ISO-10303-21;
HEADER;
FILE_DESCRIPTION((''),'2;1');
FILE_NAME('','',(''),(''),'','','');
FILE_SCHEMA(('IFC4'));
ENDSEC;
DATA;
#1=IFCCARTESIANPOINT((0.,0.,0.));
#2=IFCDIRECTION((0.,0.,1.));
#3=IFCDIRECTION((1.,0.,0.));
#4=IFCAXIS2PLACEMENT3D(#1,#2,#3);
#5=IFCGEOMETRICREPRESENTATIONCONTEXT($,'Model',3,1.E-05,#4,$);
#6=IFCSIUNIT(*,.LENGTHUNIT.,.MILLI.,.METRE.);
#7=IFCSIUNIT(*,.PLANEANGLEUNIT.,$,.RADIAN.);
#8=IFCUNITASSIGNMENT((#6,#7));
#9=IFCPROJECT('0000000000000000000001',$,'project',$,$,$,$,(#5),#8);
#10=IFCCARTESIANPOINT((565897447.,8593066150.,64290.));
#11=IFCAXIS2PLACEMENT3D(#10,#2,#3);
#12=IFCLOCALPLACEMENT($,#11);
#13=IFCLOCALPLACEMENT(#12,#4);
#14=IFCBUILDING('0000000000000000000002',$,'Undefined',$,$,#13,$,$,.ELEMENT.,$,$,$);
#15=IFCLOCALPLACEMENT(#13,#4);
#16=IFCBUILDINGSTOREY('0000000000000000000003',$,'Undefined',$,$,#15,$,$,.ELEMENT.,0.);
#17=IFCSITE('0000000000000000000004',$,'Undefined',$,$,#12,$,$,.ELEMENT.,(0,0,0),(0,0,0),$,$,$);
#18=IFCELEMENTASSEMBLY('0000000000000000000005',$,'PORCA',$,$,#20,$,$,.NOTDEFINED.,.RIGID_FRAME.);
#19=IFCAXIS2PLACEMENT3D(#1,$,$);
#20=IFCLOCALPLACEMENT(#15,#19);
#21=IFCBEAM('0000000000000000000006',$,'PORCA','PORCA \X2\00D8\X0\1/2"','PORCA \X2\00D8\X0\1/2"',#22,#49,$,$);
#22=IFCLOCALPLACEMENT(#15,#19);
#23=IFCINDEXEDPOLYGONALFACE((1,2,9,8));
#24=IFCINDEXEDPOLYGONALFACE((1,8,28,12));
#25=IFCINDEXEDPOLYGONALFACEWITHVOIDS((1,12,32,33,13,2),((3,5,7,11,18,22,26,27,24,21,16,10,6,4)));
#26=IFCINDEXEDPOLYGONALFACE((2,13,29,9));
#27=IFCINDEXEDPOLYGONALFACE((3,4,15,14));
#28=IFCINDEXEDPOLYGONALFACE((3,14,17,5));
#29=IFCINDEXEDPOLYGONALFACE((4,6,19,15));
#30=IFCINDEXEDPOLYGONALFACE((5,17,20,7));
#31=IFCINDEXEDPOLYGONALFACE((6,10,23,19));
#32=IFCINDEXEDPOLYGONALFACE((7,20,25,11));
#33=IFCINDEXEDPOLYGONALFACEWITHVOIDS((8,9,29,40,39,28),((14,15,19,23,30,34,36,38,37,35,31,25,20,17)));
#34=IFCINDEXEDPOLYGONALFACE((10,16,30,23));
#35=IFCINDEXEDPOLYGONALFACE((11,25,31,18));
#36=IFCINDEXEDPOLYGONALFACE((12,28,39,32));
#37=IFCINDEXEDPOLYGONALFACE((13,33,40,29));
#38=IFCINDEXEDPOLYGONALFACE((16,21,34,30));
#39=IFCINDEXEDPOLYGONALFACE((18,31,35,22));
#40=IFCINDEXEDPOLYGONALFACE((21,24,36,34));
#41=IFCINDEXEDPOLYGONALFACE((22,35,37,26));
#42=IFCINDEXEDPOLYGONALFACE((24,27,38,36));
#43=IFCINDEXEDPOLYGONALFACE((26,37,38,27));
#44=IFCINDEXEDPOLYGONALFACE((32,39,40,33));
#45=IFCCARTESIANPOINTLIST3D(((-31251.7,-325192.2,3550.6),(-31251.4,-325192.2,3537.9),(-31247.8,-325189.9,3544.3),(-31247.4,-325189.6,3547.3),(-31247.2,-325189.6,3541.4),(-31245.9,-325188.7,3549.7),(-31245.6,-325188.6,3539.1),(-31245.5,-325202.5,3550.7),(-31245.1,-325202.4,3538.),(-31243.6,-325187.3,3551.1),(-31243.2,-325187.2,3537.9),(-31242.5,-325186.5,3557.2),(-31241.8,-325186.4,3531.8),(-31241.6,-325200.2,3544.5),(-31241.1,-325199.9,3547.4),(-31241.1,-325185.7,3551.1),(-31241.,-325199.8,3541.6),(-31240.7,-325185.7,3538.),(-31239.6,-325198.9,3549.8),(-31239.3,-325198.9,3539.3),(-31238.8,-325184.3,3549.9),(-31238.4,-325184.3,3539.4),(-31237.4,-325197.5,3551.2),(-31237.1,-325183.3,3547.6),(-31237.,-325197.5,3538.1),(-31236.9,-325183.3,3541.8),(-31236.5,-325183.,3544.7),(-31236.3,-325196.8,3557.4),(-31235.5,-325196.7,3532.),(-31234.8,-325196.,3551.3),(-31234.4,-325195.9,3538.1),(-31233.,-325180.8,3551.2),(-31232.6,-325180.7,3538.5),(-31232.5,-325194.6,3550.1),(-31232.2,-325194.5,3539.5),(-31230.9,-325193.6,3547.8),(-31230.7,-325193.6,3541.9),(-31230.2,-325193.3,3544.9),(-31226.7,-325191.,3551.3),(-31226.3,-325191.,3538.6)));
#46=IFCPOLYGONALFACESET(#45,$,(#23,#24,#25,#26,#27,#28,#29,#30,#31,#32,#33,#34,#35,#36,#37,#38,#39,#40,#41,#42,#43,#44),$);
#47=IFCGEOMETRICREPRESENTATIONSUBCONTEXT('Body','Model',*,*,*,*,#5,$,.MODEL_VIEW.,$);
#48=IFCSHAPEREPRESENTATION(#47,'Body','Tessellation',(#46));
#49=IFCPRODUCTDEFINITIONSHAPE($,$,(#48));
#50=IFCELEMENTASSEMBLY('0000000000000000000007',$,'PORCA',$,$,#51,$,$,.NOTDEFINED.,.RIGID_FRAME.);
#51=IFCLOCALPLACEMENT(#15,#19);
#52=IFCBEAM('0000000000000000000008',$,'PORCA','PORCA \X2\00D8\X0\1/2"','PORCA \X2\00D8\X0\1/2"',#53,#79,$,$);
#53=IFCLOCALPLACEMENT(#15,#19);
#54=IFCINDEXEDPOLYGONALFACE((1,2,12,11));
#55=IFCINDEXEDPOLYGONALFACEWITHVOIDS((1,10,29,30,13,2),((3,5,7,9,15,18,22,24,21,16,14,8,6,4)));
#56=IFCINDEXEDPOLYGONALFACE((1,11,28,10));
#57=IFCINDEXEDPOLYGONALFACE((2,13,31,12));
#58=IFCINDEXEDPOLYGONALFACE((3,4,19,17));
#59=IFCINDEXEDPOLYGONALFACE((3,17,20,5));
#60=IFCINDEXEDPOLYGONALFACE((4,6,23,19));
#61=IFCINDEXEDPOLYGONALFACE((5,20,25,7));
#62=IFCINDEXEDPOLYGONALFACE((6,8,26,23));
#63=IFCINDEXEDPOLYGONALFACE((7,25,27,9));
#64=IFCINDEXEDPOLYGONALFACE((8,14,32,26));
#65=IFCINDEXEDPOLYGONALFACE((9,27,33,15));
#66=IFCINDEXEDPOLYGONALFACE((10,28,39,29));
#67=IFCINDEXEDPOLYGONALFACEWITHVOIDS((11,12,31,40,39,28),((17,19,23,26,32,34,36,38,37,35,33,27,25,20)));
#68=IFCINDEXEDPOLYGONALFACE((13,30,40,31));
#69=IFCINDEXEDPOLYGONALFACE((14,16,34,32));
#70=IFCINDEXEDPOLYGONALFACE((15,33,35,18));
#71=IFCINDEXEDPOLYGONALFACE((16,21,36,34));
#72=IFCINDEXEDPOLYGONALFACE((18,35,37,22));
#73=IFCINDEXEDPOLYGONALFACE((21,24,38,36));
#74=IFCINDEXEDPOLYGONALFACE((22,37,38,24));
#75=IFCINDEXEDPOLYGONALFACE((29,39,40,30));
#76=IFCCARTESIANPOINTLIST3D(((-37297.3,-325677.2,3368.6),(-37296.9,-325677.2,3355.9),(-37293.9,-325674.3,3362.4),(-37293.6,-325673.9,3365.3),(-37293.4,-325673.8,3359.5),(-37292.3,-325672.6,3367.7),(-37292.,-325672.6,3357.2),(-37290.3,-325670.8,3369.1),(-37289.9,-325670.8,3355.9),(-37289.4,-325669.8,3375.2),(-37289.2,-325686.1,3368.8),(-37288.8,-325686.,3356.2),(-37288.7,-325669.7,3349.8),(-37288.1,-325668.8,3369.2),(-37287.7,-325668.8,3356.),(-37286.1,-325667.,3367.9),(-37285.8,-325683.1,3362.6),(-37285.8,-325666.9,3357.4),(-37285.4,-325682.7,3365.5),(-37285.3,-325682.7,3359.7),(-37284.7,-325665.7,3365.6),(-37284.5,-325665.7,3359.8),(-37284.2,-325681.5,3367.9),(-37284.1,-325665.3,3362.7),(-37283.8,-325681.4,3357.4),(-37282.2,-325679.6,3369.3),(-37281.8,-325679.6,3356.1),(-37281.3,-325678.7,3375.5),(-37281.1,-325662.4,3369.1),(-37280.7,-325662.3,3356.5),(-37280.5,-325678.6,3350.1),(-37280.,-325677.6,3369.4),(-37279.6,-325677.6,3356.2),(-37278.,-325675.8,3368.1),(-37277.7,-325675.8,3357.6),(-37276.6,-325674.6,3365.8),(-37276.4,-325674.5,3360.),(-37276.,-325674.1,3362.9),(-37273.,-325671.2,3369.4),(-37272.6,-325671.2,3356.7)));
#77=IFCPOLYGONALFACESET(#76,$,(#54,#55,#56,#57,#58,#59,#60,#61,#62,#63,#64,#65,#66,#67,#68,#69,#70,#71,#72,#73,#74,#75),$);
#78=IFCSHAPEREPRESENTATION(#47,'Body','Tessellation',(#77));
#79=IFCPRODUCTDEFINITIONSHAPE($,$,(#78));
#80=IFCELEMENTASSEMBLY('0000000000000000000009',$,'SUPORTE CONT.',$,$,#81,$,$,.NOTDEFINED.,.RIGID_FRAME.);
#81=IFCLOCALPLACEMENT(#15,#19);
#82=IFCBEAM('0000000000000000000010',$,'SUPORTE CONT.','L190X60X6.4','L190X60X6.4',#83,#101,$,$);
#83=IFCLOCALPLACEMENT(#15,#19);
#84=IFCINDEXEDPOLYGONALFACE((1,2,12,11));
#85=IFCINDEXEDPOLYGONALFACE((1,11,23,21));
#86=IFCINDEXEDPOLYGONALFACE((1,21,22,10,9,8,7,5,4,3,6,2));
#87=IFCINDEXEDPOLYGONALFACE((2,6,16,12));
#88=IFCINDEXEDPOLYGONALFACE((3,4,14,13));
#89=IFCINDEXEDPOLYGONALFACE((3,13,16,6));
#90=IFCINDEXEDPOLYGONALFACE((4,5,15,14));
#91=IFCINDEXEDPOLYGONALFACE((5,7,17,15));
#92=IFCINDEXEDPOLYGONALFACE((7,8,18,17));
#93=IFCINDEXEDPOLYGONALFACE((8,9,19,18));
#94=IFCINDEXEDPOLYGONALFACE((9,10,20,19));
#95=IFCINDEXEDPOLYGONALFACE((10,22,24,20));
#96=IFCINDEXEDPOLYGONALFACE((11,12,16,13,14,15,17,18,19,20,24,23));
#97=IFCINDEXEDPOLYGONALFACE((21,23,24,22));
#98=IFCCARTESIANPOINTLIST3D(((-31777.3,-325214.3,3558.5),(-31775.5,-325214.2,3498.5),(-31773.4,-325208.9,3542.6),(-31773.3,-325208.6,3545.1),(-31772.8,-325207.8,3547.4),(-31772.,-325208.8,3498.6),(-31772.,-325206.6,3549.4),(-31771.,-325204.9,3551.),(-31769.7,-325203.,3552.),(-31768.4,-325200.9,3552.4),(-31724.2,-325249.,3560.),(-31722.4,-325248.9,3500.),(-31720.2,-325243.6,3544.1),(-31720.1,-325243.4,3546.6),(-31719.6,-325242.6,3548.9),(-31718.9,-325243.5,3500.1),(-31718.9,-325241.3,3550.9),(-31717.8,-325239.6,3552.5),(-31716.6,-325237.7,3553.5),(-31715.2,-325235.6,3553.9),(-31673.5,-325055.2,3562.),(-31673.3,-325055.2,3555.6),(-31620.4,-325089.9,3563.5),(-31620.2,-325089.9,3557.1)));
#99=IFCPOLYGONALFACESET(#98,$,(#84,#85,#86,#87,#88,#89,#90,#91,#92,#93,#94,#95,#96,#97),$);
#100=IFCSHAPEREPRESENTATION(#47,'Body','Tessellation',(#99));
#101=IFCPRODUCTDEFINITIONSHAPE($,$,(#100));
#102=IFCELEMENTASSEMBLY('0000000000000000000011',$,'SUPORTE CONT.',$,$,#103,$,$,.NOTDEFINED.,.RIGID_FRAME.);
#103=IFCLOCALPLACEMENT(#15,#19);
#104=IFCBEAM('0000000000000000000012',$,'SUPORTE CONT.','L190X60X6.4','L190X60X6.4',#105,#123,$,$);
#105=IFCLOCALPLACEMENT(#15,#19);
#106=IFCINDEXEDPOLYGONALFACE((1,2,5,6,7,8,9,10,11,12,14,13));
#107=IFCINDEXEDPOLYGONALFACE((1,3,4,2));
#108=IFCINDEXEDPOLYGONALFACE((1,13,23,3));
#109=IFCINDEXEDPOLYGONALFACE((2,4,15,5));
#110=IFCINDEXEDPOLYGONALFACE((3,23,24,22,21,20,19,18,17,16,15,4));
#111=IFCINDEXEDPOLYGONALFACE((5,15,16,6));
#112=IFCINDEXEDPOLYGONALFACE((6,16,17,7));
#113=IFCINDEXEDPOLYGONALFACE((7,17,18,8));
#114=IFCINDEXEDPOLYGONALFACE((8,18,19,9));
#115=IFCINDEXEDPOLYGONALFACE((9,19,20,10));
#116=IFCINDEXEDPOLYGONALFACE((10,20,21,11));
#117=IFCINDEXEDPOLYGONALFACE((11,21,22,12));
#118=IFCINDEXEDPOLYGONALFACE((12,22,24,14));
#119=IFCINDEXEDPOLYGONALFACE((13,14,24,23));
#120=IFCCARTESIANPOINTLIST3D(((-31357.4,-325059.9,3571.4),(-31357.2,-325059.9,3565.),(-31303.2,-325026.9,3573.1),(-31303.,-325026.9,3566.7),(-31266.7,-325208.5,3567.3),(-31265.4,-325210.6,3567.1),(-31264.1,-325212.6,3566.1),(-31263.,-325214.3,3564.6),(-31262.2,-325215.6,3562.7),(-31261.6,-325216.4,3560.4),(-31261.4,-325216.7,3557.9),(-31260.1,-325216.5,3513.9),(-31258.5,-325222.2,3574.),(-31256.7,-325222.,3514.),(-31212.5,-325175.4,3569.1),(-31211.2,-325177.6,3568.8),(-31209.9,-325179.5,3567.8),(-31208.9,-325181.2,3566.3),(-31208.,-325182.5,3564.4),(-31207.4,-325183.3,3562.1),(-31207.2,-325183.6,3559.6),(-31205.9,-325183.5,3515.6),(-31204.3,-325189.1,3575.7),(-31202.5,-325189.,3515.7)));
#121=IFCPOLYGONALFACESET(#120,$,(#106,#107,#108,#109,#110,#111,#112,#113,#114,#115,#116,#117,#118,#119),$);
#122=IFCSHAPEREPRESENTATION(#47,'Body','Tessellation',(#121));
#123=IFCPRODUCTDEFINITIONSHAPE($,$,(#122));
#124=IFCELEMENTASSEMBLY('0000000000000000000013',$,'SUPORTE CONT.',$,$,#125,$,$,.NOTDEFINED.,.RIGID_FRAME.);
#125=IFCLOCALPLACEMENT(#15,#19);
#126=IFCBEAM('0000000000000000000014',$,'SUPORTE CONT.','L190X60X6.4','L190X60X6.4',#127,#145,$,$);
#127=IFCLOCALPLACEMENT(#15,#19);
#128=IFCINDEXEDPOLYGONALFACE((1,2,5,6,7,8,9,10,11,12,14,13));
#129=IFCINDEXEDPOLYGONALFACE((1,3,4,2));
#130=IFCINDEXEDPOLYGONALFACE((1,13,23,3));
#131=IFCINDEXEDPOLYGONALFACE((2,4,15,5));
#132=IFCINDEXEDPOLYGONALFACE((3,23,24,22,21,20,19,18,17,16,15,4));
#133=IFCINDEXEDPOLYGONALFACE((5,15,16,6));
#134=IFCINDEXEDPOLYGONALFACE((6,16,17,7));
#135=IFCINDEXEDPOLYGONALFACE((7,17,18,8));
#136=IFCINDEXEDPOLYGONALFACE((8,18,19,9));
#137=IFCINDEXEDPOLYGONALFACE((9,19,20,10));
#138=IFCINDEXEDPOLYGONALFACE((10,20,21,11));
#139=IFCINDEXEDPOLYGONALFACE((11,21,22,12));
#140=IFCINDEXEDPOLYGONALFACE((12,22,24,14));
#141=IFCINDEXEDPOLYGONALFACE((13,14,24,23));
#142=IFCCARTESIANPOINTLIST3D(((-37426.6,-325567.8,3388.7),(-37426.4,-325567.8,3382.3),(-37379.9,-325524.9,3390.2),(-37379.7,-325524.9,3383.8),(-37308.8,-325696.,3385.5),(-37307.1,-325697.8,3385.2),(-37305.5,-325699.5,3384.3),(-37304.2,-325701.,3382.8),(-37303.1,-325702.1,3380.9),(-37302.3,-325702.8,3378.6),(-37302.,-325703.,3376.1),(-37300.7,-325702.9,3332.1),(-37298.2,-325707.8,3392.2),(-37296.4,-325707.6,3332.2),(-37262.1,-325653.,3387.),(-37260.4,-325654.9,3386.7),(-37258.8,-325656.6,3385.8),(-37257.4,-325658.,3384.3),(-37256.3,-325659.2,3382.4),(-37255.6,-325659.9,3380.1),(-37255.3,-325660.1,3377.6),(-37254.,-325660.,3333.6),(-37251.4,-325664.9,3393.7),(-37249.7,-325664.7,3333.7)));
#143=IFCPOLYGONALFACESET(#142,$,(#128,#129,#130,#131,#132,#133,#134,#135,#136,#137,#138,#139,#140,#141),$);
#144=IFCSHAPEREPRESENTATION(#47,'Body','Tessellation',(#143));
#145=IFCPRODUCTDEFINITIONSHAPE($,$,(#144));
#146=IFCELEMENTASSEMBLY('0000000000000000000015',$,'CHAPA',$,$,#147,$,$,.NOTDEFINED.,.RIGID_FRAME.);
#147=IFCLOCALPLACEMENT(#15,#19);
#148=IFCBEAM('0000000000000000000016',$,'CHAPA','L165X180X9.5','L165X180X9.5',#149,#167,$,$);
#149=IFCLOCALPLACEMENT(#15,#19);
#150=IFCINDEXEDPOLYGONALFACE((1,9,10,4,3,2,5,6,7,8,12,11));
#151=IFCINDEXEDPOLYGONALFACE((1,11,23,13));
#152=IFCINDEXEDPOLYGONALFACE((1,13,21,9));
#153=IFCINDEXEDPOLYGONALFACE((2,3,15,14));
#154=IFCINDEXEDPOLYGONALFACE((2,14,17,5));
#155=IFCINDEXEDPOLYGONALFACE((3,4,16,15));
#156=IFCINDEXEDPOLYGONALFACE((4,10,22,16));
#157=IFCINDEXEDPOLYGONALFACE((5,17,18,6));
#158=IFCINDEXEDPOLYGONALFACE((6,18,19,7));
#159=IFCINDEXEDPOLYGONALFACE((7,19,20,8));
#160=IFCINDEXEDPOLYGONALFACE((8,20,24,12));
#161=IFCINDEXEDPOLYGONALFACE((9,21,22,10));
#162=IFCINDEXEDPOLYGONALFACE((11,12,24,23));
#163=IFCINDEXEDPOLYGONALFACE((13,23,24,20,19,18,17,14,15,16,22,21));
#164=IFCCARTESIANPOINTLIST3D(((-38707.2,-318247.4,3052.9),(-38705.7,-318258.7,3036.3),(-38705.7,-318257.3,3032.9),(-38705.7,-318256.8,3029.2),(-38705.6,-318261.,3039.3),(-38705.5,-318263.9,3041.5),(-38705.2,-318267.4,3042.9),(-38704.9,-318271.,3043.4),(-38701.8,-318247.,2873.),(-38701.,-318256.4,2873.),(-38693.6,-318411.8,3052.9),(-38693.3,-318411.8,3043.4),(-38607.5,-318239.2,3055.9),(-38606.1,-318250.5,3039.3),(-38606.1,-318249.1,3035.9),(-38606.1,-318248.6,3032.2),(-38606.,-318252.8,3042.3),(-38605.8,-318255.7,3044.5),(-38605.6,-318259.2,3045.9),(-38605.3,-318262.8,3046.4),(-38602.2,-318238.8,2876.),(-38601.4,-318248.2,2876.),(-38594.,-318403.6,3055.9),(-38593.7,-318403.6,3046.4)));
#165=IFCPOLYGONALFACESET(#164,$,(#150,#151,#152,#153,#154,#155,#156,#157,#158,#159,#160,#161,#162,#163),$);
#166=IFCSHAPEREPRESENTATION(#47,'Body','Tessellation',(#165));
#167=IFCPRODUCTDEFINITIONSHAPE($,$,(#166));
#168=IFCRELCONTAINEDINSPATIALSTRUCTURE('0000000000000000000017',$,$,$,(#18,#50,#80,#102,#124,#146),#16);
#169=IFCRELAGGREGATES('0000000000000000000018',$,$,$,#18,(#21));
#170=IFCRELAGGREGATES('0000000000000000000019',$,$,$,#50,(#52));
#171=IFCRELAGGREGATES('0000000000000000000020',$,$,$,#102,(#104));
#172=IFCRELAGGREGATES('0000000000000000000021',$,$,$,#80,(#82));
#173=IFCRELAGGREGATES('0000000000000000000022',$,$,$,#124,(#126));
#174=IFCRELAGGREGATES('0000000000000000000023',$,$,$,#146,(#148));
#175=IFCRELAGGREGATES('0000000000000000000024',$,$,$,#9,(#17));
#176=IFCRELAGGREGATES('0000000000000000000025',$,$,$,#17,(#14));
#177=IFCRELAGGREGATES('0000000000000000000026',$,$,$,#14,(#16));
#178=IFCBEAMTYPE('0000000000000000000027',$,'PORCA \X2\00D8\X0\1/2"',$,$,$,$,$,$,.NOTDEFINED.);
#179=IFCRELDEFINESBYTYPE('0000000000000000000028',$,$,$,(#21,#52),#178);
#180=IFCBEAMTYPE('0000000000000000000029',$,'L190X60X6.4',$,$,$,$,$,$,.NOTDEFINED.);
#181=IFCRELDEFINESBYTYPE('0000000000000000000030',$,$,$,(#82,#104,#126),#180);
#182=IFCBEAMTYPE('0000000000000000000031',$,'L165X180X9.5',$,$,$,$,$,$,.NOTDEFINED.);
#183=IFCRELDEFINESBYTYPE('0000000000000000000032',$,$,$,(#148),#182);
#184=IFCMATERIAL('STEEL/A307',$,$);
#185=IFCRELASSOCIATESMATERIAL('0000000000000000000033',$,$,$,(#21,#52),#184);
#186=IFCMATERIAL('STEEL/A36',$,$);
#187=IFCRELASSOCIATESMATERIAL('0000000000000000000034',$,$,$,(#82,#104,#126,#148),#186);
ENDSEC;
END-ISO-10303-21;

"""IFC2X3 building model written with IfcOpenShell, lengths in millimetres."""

from ifc_helpers import new_model, si_unit, frame, origin_with_axes, origin_2d_with_axis, place, context, subcontext, project, spatial, polyline, l_section, outline, extrude, material, type_object, element, aggregate, save


model = new_model("IFC2X3")

# Units and contexts
model_context = context("Model", 3, precision=1e-05, world=origin_with_axes())
body_context = subcontext(model_context, "Body", "Model", "MODEL_VIEW")
ifc_project = project(units=[si_unit("LENGTHUNIT", "METRE", prefix="MILLI"), si_unit("PLANEANGLEUNIT", "RADIAN")], contexts=[model_context])

# Site, building, storey
site_placement = place(None, frame((565897447.0, 8593066150.0, 64290.0), z_axis=(0.0, 0.0, 1.0), x_axis=(1.0, 0.0, 0.0)))
site = spatial("IfcSite", under=ifc_project, at=site_placement, Name="Undefined", CompositionType="ELEMENT", RefLatitude=(0, 0, 0), RefLongitude=(0, 0, 0))
building_placement = place(site_placement, origin_with_axes())
building = spatial("IfcBuilding", under=site, at=building_placement, Name="Undefined", CompositionType="ELEMENT")
storey_placement = place(building_placement, origin_with_axes())
storey = spatial("IfcBuildingStorey", under=building, at=storey_placement, Name="Undefined", CompositionType="ELEMENT", Elevation=0.0)

# Element assemblies, beams
ifc_material_1 = material(Name="STEEL/A36")
ifc_material_2 = material(Name="STEEL/A307")
beam_type_1 = type_object("IfcBeamType", Name="PORCA Ø1/2\"", PredefinedType="NOTDEFINED")
assembly_1_placement = place(storey_placement, origin_with_axes())
assembly_1 = element("IfcElementAssembly", 1, at=assembly_1_placement, inside=storey, Name="PORCA", AssemblyPlace="NOTDEFINED", PredefinedType="RIGID_FRAME")
beam_1_placement = place(assembly_1_placement, frame((-31242.2, -325186.5, 3544.5), z_axis=(0.853486, 0.520426, 0.026799), x_axis=(0.520257, -0.853904, 0.013454)))
beam_1 = element("IfcBeam", 2, at=beam_1_placement, type_object=beam_type_1, material=ifc_material_2, Name="PORCA", Description="PORCA Ø1/2\"", ObjectType="PORCA Ø1/2\"", context=body_context, shape_type="SweptSolid", body=[
    extrude(outline(polyline([(-12.7, 0.0), (-6.3, 11.0), (6.3, 11.0), (12.7, 0.0), (6.3, -11.0), (-6.3, -11.0), (-12.7, 0.0)]), holes=[polyline([(5.3, 4.2), (2.9, 6.0), (0.0, 6.7), (-2.9, 6.0), (-5.3, 4.2), (-6.6, 1.5), (-6.6, -1.5), (-5.3, -4.2), (-2.9, -6.0), (0.0, -6.7), (2.9, -6.0), (5.3, -4.2), (6.6, -1.5), (6.6, 1.5), (5.3, 4.2)])]), frame((12.0, 0.0, 0.0), z_axis=(-1.0, 0.0, 0.0), x_axis=(0.0, -1.0, 0.0)), (0.0, 0.0, 1.0), 12.0),
])
aggregate(assembly_1, [beam_1])
assembly_2_placement = place(storey_placement, origin_with_axes())
assembly_2 = element("IfcElementAssembly", 3, at=assembly_2_placement, inside=storey, Name="PORCA", AssemblyPlace="NOTDEFINED", PredefinedType="RIGID_FRAME")
beam_2_placement = place(assembly_2_placement, frame((-37289.0, -325669.8, 3362.5), z_axis=(0.736334, 0.676203, 0.02368), x_axis=(0.675958, -0.736711, 0.018398)))
beam_2 = element("IfcBeam", 4, at=beam_2_placement, type_object=beam_type_1, material=ifc_material_2, Name="PORCA", Description="PORCA Ø1/2\"", ObjectType="PORCA Ø1/2\"", context=body_context, shape_type="SweptSolid", body=[
    extrude(outline(polyline([(-12.7, 0.0), (-6.3, 11.0), (6.3, 11.0), (12.7, 0.0), (6.3, -11.0), (-6.3, -11.0), (-12.7, 0.0)]), holes=[polyline([(5.3, 4.2), (2.9, 6.0), (0.0, 6.7), (-2.9, 6.0), (-5.3, 4.2), (-6.6, 1.5), (-6.6, -1.5), (-5.3, -4.2), (-2.9, -6.0), (0.0, -6.7), (2.9, -6.0), (5.3, -4.2), (6.6, -1.5), (6.6, 1.5), (5.3, 4.2)])]), frame((12.0, 0.0, 0.0), z_axis=(-1.0, 0.0, 0.0), x_axis=(0.0, -1.0, 0.0)), (0.0, 0.0, 1.0), 12.0),
])
aggregate(assembly_2, [beam_2])
assembly_3_placement = place(storey_placement, origin_with_axes())
assembly_3 = element("IfcElementAssembly", 5, at=assembly_3_placement, inside=storey, Name="SUPORTE CONT.", AssemblyPlace="NOTDEFINED", PredefinedType="RIGID_FRAME")
beam_type_2 = type_object("IfcBeamType", Name="L190X60X6.4", PredefinedType="NOTDEFINED")
beam_3_placement = place(assembly_3_placement, frame((-31671.4, -325169.4, 3531.7), z_axis=(0.546411, 0.837315, 0.018398), x_axis=(-0.836984, 0.546715, -0.02368)))
beam_3 = element("IfcBeam", 6, at=beam_3_placement, type_object=beam_type_2, material=ifc_material_1, Name="SUPORTE CONT.", Description="L190X60X6.4", ObjectType="L190X60X6.4", context=body_context, shape_type="SweptSolid", body=[
    extrude(l_section(Depth=190.0, Width=60.0, Thickness=6.4, FilletRadius=9.6, at=origin_2d_with_axis()), frame((63.5, 0.0, 0.0), z_axis=(-1.0, 0.0, 0.0), x_axis=(0.0, -1.0, 0.0)), (0.0, 0.0, 1.0), 63.5),
])
assembly_4_placement = place(storey_placement, origin_with_axes())
assembly_4 = element("IfcElementAssembly", 7, at=assembly_4_placement, inside=storey, Name="SUPORTE CONT.", AssemblyPlace="NOTDEFINED", PredefinedType="RIGID_FRAME")
beam_4_placement = place(assembly_4_placement, frame((-31252.9, -325107.9, 3544.4), z_axis=(-0.520257, 0.853904, -0.013454), x_axis=(-0.853486, -0.520426, -0.026799)))
beam_4 = element("IfcBeam", 8, at=beam_4_placement, type_object=beam_type_2, material=ifc_material_1, Name="SUPORTE CONT.", Description="L190X60X6.4", ObjectType="L190X60X6.4", context=body_context, shape_type="SweptSolid", body=[
    extrude(l_section(Depth=190.0, Width=60.0, Thickness=6.4, FilletRadius=9.6, at=origin_2d_with_axis()), frame((63.5, 0.0, 0.0), z_axis=(-1.0, 0.0, 0.0), x_axis=(0.0, -1.0, 0.0)), (0.0, 0.0, 1.0), 63.5),
])
aggregate(assembly_4, [beam_4])
assembly_5_placement = place(storey_placement, origin_with_axes())
assembly_5 = element("IfcElementAssembly", 9, at=assembly_5_placement, inside=storey, Name="SUPORTE CONT.", AssemblyPlace="NOTDEFINED", PredefinedType="RIGID_FRAME")
beam_5_placement = place(assembly_5_placement, frame((-37314.8, -325594.8, 3362.0), z_axis=(-0.675958, 0.736711, -0.018398), x_axis=(-0.736334, -0.676203, -0.02368)))
beam_5 = element("IfcBeam", 10, at=beam_5_placement, type_object=beam_type_2, material=ifc_material_1, Name="SUPORTE CONT.", Description="L190X60X6.4", ObjectType="L190X60X6.4", context=body_context, shape_type="SweptSolid", body=[
    extrude(l_section(Depth=190.0, Width=60.0, Thickness=6.4, FilletRadius=9.6, at=origin_2d_with_axis()), frame((63.5, 0.0, 0.0), z_axis=(-1.0, 0.0, 0.0), x_axis=(0.0, -1.0, 0.0)), (0.0, 0.0, 1.0), 63.5),
])
assembly_6_placement = place(storey_placement, origin_with_axes())
assembly_6 = element("IfcElementAssembly", 11, at=assembly_6_placement, inside=storey, Name="CHAPA", AssemblyPlace="NOTDEFINED", PredefinedType="RIGID_FRAME")
beam_type_3 = type_object("IfcBeamType", Name="L165X180X9.5", PredefinedType="NOTDEFINED")
beam_6_placement = place(assembly_6_placement, frame((-38697.7, -318329.4, 2963.0), z_axis=(0.082025, -0.99663, 0.0), x_axis=(0.996182, 0.081989, 0.029987)))
beam_6 = element("IfcBeam", 12, at=beam_6_placement, type_object=beam_type_3, material=ifc_material_1, Name="CHAPA", Description="L165X180X9.5", ObjectType="L165X180X9.5", context=body_context, shape_type="SweptSolid", body=[
    extrude(l_section(Depth=165.0, Width=180.0, Thickness=9.5, FilletRadius=14.2, at=origin_2d_with_axis()), frame((100.0, 0.0, 0.0), z_axis=(-1.0, 0.0, 0.0), x_axis=(0.0, -1.0, 0.0)), (0.0, 0.0, 1.0), 100.0),
])

aggregate(assembly_3, [beam_3])
aggregate(assembly_5, [beam_5])

aggregate(assembly_6, [beam_6])

save(model, "model.ifc")
